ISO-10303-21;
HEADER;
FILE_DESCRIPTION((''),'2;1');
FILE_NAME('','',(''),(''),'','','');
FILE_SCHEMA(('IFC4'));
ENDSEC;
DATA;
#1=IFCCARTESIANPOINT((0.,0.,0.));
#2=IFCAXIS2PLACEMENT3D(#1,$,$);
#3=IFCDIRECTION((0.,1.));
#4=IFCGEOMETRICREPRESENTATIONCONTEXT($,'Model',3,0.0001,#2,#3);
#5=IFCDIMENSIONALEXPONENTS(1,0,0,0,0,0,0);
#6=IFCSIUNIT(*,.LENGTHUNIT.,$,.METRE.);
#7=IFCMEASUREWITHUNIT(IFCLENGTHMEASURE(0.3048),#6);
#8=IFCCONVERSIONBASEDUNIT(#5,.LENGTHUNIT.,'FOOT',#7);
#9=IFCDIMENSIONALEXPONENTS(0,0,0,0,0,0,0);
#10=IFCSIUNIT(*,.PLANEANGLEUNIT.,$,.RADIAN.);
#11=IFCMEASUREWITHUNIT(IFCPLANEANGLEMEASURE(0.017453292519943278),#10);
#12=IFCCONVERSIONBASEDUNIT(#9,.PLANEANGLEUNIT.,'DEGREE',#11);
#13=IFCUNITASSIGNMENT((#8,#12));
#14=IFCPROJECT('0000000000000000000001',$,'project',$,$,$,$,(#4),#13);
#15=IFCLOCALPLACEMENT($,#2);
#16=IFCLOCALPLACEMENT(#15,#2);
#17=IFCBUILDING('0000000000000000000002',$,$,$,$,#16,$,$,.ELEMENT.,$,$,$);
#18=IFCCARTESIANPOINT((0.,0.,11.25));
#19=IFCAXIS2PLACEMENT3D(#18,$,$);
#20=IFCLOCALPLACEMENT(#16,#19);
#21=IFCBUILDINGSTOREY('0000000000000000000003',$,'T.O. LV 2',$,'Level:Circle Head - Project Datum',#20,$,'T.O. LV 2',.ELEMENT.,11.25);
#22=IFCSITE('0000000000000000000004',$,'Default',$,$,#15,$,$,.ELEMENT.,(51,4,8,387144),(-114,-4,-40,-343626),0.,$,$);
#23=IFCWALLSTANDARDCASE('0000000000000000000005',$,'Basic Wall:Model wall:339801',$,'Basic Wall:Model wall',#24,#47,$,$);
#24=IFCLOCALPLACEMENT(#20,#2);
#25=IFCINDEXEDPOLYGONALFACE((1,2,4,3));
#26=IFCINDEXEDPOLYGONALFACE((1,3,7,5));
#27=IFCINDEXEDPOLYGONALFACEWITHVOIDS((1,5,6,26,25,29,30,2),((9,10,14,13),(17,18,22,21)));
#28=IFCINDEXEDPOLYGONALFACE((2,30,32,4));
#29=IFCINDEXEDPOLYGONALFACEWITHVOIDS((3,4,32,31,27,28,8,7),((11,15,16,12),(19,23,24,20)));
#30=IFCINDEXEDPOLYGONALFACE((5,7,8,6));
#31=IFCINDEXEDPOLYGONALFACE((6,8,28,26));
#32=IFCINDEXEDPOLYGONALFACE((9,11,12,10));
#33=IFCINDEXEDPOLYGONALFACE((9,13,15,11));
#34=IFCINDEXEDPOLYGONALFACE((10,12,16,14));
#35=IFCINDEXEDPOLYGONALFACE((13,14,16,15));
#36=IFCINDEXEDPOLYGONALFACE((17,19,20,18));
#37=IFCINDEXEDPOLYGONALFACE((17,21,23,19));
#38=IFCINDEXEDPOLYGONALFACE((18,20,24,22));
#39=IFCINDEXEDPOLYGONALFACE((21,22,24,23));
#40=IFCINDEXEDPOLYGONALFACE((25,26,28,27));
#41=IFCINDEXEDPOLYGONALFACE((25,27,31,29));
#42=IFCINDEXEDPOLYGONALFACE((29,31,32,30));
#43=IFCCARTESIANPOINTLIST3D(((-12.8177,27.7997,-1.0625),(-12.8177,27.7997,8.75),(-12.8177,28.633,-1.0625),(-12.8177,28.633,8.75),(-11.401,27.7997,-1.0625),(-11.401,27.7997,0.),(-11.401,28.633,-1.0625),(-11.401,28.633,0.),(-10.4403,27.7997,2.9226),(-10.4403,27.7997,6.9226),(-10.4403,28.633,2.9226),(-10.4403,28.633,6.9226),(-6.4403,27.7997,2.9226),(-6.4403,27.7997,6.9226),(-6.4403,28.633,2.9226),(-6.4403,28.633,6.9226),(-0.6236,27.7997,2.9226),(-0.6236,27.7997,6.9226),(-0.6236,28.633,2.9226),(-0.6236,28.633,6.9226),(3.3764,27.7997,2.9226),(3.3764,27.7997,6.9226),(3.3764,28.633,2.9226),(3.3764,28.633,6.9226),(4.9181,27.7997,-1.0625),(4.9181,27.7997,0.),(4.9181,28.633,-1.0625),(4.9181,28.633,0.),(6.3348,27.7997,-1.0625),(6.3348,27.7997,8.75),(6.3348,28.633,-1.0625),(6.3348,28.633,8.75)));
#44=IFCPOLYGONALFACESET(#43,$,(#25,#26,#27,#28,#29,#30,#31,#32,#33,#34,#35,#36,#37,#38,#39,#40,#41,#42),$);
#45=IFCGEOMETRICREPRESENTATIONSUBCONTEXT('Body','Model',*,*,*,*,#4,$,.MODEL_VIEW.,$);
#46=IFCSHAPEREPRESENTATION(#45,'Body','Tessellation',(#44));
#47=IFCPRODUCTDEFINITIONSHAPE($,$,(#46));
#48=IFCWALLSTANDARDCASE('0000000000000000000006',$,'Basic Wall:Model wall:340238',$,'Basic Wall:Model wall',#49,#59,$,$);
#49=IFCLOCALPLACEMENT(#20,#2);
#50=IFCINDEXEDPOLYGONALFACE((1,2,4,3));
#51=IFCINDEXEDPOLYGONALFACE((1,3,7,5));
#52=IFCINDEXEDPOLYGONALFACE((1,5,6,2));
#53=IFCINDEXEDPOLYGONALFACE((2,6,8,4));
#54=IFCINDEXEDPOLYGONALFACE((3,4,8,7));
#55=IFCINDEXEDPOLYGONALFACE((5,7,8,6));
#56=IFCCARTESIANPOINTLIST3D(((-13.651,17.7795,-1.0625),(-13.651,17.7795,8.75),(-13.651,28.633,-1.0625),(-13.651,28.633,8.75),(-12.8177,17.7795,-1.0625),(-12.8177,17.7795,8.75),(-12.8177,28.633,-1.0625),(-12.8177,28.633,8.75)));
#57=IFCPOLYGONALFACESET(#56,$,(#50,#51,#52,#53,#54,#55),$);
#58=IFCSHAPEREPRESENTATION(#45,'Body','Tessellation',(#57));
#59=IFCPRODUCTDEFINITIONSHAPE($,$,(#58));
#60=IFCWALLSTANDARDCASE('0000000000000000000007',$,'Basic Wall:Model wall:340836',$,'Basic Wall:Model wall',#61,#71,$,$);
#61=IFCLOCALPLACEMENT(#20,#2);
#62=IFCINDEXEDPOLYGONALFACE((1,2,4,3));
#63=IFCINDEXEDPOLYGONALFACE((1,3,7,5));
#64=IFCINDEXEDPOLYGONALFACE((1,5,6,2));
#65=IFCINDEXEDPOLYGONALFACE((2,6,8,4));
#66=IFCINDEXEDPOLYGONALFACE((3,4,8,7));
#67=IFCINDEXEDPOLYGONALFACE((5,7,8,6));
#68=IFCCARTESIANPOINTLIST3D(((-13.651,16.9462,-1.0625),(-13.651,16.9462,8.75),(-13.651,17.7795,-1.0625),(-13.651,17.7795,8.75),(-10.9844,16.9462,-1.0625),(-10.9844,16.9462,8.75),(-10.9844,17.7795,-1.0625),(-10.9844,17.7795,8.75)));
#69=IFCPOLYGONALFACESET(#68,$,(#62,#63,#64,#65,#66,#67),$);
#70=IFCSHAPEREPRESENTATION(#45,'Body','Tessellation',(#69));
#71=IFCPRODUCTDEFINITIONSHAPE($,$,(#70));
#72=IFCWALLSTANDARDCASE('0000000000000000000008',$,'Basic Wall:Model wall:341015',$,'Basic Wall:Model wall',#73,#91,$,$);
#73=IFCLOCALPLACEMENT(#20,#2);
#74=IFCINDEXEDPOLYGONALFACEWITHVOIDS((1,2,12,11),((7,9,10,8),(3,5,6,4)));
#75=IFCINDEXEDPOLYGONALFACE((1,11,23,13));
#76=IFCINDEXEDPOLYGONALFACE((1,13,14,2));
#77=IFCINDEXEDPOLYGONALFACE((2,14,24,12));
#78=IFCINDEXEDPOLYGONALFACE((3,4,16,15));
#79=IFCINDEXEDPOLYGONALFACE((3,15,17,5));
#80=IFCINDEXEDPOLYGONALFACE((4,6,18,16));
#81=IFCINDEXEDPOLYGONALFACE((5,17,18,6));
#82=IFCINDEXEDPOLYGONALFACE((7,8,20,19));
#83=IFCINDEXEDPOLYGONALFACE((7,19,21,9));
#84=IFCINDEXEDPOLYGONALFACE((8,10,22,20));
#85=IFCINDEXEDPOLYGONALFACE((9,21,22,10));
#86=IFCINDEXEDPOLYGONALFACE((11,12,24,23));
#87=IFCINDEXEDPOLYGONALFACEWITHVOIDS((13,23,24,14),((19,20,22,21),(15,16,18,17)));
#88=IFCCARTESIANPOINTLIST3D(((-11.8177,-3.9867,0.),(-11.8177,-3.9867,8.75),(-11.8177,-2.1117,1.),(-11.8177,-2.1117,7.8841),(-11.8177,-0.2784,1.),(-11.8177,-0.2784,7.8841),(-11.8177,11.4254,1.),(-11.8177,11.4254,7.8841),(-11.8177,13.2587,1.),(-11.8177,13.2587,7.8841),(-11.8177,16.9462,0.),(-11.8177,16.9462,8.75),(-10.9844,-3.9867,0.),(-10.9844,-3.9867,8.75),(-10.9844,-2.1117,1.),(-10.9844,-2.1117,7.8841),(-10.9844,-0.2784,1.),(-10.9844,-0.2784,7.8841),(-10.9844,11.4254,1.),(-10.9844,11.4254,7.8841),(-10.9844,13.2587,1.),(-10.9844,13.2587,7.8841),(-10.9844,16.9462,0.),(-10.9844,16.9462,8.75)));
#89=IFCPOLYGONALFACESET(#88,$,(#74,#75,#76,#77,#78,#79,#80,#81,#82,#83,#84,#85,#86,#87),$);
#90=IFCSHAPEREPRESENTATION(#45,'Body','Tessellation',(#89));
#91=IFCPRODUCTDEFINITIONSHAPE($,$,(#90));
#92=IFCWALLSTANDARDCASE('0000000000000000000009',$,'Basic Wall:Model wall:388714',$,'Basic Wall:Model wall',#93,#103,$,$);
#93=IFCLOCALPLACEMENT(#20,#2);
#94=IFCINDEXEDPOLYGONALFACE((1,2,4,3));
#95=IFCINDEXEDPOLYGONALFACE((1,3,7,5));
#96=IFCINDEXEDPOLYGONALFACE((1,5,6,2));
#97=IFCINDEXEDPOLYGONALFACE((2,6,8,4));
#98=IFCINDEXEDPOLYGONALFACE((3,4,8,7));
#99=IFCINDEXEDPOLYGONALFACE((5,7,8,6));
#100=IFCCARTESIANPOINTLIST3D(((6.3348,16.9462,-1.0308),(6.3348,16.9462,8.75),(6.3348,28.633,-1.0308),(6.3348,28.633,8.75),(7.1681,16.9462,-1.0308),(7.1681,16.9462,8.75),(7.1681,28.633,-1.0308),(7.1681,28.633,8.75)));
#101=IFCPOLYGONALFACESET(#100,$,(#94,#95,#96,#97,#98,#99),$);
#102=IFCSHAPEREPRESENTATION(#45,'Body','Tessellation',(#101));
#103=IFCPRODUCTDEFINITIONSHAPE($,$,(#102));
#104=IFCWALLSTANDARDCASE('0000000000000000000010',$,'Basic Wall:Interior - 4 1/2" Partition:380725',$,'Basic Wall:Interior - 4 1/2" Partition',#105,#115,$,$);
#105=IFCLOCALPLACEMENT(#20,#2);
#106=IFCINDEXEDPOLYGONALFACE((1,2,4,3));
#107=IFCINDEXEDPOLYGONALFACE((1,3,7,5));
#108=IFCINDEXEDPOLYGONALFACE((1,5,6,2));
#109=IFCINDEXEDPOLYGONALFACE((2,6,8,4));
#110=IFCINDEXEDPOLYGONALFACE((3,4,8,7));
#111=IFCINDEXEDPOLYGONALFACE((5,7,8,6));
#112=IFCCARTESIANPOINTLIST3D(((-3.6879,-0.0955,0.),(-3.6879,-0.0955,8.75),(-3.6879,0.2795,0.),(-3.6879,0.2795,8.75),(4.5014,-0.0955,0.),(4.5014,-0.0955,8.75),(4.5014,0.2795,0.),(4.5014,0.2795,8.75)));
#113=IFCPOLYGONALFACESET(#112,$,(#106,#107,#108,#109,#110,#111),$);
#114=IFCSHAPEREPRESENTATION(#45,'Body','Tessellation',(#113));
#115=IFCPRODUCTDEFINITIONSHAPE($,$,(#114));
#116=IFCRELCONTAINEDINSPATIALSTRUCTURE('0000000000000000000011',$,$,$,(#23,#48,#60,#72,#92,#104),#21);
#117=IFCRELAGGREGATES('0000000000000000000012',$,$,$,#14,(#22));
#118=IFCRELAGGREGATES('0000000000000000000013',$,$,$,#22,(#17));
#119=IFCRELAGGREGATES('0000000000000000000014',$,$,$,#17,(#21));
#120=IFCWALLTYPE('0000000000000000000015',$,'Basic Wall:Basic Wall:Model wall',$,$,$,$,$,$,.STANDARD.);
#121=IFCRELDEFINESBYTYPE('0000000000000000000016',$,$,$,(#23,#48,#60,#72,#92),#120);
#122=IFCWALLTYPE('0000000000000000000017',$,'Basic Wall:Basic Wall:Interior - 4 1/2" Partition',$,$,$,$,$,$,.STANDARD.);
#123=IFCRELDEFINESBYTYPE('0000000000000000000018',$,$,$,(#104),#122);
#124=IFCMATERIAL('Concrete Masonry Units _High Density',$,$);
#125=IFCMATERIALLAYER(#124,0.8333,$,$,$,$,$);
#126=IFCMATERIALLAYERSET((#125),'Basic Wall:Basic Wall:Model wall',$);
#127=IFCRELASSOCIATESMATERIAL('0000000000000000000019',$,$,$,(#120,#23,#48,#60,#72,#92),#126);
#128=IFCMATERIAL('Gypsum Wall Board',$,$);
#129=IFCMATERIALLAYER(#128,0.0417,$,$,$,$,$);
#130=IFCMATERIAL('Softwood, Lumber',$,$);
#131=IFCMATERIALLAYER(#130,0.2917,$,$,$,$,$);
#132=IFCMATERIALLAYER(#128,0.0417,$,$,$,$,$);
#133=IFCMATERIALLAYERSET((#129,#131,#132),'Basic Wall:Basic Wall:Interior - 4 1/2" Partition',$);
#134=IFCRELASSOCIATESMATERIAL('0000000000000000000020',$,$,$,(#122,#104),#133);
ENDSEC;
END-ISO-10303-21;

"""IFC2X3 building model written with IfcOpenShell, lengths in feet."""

from ifc_helpers import new_model, entity, si_unit, converted_unit, direction, frame, frame_2d, origin, origin_2d_with_axis, place, context, subcontext, project, spatial, rectangle, extrude, material, layer, layer_set, layer_usage, type_object, element, save


model = new_model("IFC2X3")

# Units and contexts
model_context = context("Model", 3, precision=0.0001, world=origin(), true_north=direction((0.0, 1.0)))
body_context = subcontext(model_context, "Body", "Model", "MODEL_VIEW")
ifc_project = project(units=[converted_unit("LENGTHUNIT", "FOOT", entity("IfcLengthMeasure", 0.3048), si_unit("LENGTHUNIT", "METRE"), dimensions=[1, 0, 0, 0, 0, 0, 0]), converted_unit("PLANEANGLEUNIT", "DEGREE", entity("IfcPlaneAngleMeasure", 0.017453292519943278), si_unit("PLANEANGLEUNIT", "RADIAN"), dimensions=[0, 0, 0, 0, 0, 0, 0])], contexts=[model_context])

# Site, building, storey
site_placement = place(None, origin())
site = spatial("IfcSite", under=ifc_project, at=site_placement, Name="Default", CompositionType="ELEMENT", RefLatitude=(51, 4, 8, 387144), RefLongitude=(-114, -4, -40, -343626), RefElevation=0.0)
building_placement = place(site_placement, origin())
building = spatial("IfcBuilding", under=site, at=building_placement, CompositionType="ELEMENT")
storey_placement = place(building_placement, frame((0.0, 0.0, 11.25)))
storey = spatial("IfcBuildingStorey", under=building, at=storey_placement, Name="T.O. LV 2", ObjectType="Level:Circle Head - Project Datum", LongName="T.O. LV 2", CompositionType="ELEMENT", Elevation=11.25)

# Wall, openings
ifc_material_1 = material(Name="Concrete Masonry Units _High Density")
ifc_layer_1 = layer(ifc_material_1, 0.8333)
ifc_layer_set_1 = layer_set([ifc_layer_1], Name="Basic Wall:Basic Wall:Model wall")
ifc_layer_usage_1 = layer_usage(ifc_layer_set_1, "AXIS2", "NEGATIVE", 0.4167)
wall_type_1 = type_object("IfcWallType", Name="Basic Wall:Basic Wall:Model wall", PredefinedType="STANDARD", material=ifc_layer_set_1)
wall_1_placement = place(storey_placement, frame((-12.8177, 28.2164, -1.0625)))
wall_1 = element("IfcWallStandardCase", 1, at=wall_1_placement, inside=storey, type_object=wall_type_1, material=ifc_layer_usage_1, Name="Basic Wall:Model wall:339801", ObjectType="Basic Wall:Model wall", context=body_context, shape_type="SweptSolid", body=[
    extrude(rectangle(XDim=19.1525, YDim=0.8333, at=frame_2d((9.5762, 0.0), x_axis=(-1.0, 0.0))), origin(), (0.0, 0.0, 1.0), 9.8125),
])
opening_1_placement = place(wall_1_placement, origin())
element("IfcOpeningElement", 2, at=opening_1_placement, cuts=wall_1, ObjectType="Opening", context=body_context, shape_type="SweptSolid", body=[
    extrude(rectangle(XDim=1.0625, YDim=16.3192, at=origin_2d_with_axis()), frame((9.5762, -0.4167, 0.5313), z_axis=(0.0, 1.0, 0.0), x_axis=(0.0, 0.0, -1.0)), (0.0, 0.0, 1.0), 0.8333),
])
opening_2_placement = place(wall_1_placement, frame((12.8177, -28.2164, 1.0625)))
element("IfcOpeningElement", 3, at=opening_2_placement, cuts=wall_1, ObjectType="Opening", context=body_context, shape_type="SweptSolid", body=[
    extrude(rectangle(XDim=4.0, YDim=4.0, at=frame_2d((0.0, 0.0), x_axis=(0.0, 1.0))), frame((-8.4403, 27.7914, 4.9226), z_axis=(0.0, 1.0, 0.0), x_axis=(-1.0, 0.0, 0.0)), (0.0, 0.0, 1.0), 0.85),
])
opening_3_placement = place(wall_1_placement, frame((12.8177, -28.2164, 1.0625)))
element("IfcOpeningElement", 4, at=opening_3_placement, cuts=wall_1, ObjectType="Opening", context=body_context, shape_type="SweptSolid", body=[
    extrude(rectangle(XDim=4.0, YDim=4.0, at=frame_2d((0.0, 0.0), x_axis=(0.0, 1.0))), frame((1.3764, 27.7914, 4.9226), z_axis=(0.0, 1.0, 0.0), x_axis=(-1.0, 0.0, 0.0)), (0.0, 0.0, 1.0), 0.85),
])

# Walls
ifc_layer_usage_2 = layer_usage(ifc_layer_set_1, "AXIS2", "NEGATIVE", 0.4167)
wall_2_placement = place(storey_placement, frame((-13.2344, 28.633, -1.0625), z_axis=(0.0, 0.0, 1.0), x_axis=(0.0, -1.0, 0.0)))
element("IfcWallStandardCase", 5, at=wall_2_placement, inside=storey, type_object=wall_type_1, material=ifc_layer_usage_2, Name="Basic Wall:Model wall:340238", ObjectType="Basic Wall:Model wall", context=body_context, shape_type="SweptSolid", body=[
    extrude(rectangle(XDim=10.8535, YDim=0.8333, at=frame_2d((5.4268, 0.0), x_axis=(-1.0, 0.0))), origin(), (0.0, 0.0, 1.0), 9.8125),
])
ifc_layer_usage_3 = layer_usage(ifc_layer_set_1, "AXIS2", "NEGATIVE", 0.4167)
wall_3_placement = place(storey_placement, frame((-13.651, 17.3629, -1.0625)))
element("IfcWallStandardCase", 6, at=wall_3_placement, inside=storey, type_object=wall_type_1, material=ifc_layer_usage_3, Name="Basic Wall:Model wall:340836", ObjectType="Basic Wall:Model wall", context=body_context, shape_type="SweptSolid", body=[
    extrude(rectangle(XDim=2.6667, YDim=0.8333, at=frame_2d((1.3333, 0.0), x_axis=(-1.0, 0.0))), origin(), (0.0, 0.0, 1.0), 9.8125),
])

# Wall, openings
ifc_layer_usage_4 = layer_usage(ifc_layer_set_1, "AXIS2", "NEGATIVE", 0.4167)
wall_4_placement = place(storey_placement, frame((-11.401, 16.9462, 0.0), z_axis=(0.0, 0.0, 1.0), x_axis=(0.0, -1.0, 0.0)))
wall_4 = element("IfcWallStandardCase", 7, at=wall_4_placement, inside=storey, type_object=wall_type_1, material=ifc_layer_usage_4, Name="Basic Wall:Model wall:341015", ObjectType="Basic Wall:Model wall", context=body_context, shape_type="SweptSolid", body=[
    extrude(rectangle(XDim=20.9329, YDim=0.8333, at=frame_2d((10.4665, 0.0), x_axis=(-1.0, 0.0))), origin(), (0.0, 0.0, 1.0), 8.75),
])
opening_4_placement = place(wall_4_placement, frame((16.9462, 11.401, 0.0), z_axis=(0.0, 0.0, 1.0), x_axis=(0.0, 1.0, 0.0)))
element("IfcOpeningElement", 8, at=opening_4_placement, cuts=wall_4, ObjectType="Opening", context=body_context, shape_type="SweptSolid", body=[
    extrude(rectangle(XDim=6.8841, YDim=1.8333, at=frame_2d((0.0, 0.0), x_axis=(0.0, 1.0))), frame((-11.826, -1.1951, 4.4421), z_axis=(1.0, 0.0, 0.0), x_axis=(0.0, 1.0, 0.0)), (0.0, 0.0, 1.0), 0.85),
])
opening_5_placement = place(wall_4_placement, frame((16.9462, 11.401, 0.0), z_axis=(0.0, 0.0, 1.0), x_axis=(0.0, 1.0, 0.0)))
element("IfcOpeningElement", 9, at=opening_5_placement, cuts=wall_4, ObjectType="Opening", context=body_context, shape_type="SweptSolid", body=[
    extrude(rectangle(XDim=6.8841, YDim=1.8333, at=frame_2d((0.0, 0.0), x_axis=(0.0, 1.0))), frame((-11.826, 12.342, 4.4421), z_axis=(1.0, 0.0, 0.0), x_axis=(0.0, 1.0, 0.0)), (0.0, 0.0, 1.0), 0.85),
])

# Walls
ifc_layer_usage_5 = layer_usage(ifc_layer_set_1, "AXIS2", "NEGATIVE", 0.4167)
wall_5_placement = place(storey_placement, frame((6.7514, 28.633, -1.0308), z_axis=(0.0, 0.0, 1.0), x_axis=(0.0, -1.0, 0.0)))
element("IfcWallStandardCase", 10, at=wall_5_placement, inside=storey, type_object=wall_type_1, material=ifc_layer_usage_5, Name="Basic Wall:Model wall:388714", ObjectType="Basic Wall:Model wall", context=body_context, shape_type="SweptSolid", body=[
    extrude(rectangle(XDim=11.6868, YDim=0.8333, at=frame_2d((5.8434, 0.0), x_axis=(-1.0, 0.0))), origin(), (0.0, 0.0, 1.0), 9.7808),
])
ifc_material_2 = material(Name="Gypsum Wall Board")
ifc_layer_2 = layer(ifc_material_2, 0.0417)
ifc_material_3 = material(Name="Softwood, Lumber")
ifc_layer_3 = layer(ifc_material_3, 0.2917)
ifc_layer_4 = layer(ifc_material_2, 0.0417)
ifc_layer_set_2 = layer_set([ifc_layer_2, ifc_layer_3, ifc_layer_4], Name="Basic Wall:Basic Wall:Interior - 4 1/2\" Partition")
ifc_layer_usage_6 = layer_usage(ifc_layer_set_2, "AXIS2", "NEGATIVE", 0.1875)
wall_type_2 = type_object("IfcWallType", Name="Basic Wall:Basic Wall:Interior - 4 1/2\" Partition", PredefinedType="STANDARD", material=ifc_layer_set_2)
wall_6_placement = place(storey_placement, frame((-3.6879, 0.092, 0.0)))
element("IfcWallStandardCase", 11, at=wall_6_placement, inside=storey, type_object=wall_type_2, material=ifc_layer_usage_6, Name="Basic Wall:Interior - 4 1/2\" Partition:380725", ObjectType="Basic Wall:Interior - 4 1/2\" Partition", context=body_context, shape_type="SweptSolid", body=[
    extrude(rectangle(XDim=8.1893, YDim=0.375, at=frame_2d((4.0947, 0.0), x_axis=(-1.0, 0.0))), origin(), (0.0, 0.0, 1.0), 8.75),
])

save(model, "model.ifc")
